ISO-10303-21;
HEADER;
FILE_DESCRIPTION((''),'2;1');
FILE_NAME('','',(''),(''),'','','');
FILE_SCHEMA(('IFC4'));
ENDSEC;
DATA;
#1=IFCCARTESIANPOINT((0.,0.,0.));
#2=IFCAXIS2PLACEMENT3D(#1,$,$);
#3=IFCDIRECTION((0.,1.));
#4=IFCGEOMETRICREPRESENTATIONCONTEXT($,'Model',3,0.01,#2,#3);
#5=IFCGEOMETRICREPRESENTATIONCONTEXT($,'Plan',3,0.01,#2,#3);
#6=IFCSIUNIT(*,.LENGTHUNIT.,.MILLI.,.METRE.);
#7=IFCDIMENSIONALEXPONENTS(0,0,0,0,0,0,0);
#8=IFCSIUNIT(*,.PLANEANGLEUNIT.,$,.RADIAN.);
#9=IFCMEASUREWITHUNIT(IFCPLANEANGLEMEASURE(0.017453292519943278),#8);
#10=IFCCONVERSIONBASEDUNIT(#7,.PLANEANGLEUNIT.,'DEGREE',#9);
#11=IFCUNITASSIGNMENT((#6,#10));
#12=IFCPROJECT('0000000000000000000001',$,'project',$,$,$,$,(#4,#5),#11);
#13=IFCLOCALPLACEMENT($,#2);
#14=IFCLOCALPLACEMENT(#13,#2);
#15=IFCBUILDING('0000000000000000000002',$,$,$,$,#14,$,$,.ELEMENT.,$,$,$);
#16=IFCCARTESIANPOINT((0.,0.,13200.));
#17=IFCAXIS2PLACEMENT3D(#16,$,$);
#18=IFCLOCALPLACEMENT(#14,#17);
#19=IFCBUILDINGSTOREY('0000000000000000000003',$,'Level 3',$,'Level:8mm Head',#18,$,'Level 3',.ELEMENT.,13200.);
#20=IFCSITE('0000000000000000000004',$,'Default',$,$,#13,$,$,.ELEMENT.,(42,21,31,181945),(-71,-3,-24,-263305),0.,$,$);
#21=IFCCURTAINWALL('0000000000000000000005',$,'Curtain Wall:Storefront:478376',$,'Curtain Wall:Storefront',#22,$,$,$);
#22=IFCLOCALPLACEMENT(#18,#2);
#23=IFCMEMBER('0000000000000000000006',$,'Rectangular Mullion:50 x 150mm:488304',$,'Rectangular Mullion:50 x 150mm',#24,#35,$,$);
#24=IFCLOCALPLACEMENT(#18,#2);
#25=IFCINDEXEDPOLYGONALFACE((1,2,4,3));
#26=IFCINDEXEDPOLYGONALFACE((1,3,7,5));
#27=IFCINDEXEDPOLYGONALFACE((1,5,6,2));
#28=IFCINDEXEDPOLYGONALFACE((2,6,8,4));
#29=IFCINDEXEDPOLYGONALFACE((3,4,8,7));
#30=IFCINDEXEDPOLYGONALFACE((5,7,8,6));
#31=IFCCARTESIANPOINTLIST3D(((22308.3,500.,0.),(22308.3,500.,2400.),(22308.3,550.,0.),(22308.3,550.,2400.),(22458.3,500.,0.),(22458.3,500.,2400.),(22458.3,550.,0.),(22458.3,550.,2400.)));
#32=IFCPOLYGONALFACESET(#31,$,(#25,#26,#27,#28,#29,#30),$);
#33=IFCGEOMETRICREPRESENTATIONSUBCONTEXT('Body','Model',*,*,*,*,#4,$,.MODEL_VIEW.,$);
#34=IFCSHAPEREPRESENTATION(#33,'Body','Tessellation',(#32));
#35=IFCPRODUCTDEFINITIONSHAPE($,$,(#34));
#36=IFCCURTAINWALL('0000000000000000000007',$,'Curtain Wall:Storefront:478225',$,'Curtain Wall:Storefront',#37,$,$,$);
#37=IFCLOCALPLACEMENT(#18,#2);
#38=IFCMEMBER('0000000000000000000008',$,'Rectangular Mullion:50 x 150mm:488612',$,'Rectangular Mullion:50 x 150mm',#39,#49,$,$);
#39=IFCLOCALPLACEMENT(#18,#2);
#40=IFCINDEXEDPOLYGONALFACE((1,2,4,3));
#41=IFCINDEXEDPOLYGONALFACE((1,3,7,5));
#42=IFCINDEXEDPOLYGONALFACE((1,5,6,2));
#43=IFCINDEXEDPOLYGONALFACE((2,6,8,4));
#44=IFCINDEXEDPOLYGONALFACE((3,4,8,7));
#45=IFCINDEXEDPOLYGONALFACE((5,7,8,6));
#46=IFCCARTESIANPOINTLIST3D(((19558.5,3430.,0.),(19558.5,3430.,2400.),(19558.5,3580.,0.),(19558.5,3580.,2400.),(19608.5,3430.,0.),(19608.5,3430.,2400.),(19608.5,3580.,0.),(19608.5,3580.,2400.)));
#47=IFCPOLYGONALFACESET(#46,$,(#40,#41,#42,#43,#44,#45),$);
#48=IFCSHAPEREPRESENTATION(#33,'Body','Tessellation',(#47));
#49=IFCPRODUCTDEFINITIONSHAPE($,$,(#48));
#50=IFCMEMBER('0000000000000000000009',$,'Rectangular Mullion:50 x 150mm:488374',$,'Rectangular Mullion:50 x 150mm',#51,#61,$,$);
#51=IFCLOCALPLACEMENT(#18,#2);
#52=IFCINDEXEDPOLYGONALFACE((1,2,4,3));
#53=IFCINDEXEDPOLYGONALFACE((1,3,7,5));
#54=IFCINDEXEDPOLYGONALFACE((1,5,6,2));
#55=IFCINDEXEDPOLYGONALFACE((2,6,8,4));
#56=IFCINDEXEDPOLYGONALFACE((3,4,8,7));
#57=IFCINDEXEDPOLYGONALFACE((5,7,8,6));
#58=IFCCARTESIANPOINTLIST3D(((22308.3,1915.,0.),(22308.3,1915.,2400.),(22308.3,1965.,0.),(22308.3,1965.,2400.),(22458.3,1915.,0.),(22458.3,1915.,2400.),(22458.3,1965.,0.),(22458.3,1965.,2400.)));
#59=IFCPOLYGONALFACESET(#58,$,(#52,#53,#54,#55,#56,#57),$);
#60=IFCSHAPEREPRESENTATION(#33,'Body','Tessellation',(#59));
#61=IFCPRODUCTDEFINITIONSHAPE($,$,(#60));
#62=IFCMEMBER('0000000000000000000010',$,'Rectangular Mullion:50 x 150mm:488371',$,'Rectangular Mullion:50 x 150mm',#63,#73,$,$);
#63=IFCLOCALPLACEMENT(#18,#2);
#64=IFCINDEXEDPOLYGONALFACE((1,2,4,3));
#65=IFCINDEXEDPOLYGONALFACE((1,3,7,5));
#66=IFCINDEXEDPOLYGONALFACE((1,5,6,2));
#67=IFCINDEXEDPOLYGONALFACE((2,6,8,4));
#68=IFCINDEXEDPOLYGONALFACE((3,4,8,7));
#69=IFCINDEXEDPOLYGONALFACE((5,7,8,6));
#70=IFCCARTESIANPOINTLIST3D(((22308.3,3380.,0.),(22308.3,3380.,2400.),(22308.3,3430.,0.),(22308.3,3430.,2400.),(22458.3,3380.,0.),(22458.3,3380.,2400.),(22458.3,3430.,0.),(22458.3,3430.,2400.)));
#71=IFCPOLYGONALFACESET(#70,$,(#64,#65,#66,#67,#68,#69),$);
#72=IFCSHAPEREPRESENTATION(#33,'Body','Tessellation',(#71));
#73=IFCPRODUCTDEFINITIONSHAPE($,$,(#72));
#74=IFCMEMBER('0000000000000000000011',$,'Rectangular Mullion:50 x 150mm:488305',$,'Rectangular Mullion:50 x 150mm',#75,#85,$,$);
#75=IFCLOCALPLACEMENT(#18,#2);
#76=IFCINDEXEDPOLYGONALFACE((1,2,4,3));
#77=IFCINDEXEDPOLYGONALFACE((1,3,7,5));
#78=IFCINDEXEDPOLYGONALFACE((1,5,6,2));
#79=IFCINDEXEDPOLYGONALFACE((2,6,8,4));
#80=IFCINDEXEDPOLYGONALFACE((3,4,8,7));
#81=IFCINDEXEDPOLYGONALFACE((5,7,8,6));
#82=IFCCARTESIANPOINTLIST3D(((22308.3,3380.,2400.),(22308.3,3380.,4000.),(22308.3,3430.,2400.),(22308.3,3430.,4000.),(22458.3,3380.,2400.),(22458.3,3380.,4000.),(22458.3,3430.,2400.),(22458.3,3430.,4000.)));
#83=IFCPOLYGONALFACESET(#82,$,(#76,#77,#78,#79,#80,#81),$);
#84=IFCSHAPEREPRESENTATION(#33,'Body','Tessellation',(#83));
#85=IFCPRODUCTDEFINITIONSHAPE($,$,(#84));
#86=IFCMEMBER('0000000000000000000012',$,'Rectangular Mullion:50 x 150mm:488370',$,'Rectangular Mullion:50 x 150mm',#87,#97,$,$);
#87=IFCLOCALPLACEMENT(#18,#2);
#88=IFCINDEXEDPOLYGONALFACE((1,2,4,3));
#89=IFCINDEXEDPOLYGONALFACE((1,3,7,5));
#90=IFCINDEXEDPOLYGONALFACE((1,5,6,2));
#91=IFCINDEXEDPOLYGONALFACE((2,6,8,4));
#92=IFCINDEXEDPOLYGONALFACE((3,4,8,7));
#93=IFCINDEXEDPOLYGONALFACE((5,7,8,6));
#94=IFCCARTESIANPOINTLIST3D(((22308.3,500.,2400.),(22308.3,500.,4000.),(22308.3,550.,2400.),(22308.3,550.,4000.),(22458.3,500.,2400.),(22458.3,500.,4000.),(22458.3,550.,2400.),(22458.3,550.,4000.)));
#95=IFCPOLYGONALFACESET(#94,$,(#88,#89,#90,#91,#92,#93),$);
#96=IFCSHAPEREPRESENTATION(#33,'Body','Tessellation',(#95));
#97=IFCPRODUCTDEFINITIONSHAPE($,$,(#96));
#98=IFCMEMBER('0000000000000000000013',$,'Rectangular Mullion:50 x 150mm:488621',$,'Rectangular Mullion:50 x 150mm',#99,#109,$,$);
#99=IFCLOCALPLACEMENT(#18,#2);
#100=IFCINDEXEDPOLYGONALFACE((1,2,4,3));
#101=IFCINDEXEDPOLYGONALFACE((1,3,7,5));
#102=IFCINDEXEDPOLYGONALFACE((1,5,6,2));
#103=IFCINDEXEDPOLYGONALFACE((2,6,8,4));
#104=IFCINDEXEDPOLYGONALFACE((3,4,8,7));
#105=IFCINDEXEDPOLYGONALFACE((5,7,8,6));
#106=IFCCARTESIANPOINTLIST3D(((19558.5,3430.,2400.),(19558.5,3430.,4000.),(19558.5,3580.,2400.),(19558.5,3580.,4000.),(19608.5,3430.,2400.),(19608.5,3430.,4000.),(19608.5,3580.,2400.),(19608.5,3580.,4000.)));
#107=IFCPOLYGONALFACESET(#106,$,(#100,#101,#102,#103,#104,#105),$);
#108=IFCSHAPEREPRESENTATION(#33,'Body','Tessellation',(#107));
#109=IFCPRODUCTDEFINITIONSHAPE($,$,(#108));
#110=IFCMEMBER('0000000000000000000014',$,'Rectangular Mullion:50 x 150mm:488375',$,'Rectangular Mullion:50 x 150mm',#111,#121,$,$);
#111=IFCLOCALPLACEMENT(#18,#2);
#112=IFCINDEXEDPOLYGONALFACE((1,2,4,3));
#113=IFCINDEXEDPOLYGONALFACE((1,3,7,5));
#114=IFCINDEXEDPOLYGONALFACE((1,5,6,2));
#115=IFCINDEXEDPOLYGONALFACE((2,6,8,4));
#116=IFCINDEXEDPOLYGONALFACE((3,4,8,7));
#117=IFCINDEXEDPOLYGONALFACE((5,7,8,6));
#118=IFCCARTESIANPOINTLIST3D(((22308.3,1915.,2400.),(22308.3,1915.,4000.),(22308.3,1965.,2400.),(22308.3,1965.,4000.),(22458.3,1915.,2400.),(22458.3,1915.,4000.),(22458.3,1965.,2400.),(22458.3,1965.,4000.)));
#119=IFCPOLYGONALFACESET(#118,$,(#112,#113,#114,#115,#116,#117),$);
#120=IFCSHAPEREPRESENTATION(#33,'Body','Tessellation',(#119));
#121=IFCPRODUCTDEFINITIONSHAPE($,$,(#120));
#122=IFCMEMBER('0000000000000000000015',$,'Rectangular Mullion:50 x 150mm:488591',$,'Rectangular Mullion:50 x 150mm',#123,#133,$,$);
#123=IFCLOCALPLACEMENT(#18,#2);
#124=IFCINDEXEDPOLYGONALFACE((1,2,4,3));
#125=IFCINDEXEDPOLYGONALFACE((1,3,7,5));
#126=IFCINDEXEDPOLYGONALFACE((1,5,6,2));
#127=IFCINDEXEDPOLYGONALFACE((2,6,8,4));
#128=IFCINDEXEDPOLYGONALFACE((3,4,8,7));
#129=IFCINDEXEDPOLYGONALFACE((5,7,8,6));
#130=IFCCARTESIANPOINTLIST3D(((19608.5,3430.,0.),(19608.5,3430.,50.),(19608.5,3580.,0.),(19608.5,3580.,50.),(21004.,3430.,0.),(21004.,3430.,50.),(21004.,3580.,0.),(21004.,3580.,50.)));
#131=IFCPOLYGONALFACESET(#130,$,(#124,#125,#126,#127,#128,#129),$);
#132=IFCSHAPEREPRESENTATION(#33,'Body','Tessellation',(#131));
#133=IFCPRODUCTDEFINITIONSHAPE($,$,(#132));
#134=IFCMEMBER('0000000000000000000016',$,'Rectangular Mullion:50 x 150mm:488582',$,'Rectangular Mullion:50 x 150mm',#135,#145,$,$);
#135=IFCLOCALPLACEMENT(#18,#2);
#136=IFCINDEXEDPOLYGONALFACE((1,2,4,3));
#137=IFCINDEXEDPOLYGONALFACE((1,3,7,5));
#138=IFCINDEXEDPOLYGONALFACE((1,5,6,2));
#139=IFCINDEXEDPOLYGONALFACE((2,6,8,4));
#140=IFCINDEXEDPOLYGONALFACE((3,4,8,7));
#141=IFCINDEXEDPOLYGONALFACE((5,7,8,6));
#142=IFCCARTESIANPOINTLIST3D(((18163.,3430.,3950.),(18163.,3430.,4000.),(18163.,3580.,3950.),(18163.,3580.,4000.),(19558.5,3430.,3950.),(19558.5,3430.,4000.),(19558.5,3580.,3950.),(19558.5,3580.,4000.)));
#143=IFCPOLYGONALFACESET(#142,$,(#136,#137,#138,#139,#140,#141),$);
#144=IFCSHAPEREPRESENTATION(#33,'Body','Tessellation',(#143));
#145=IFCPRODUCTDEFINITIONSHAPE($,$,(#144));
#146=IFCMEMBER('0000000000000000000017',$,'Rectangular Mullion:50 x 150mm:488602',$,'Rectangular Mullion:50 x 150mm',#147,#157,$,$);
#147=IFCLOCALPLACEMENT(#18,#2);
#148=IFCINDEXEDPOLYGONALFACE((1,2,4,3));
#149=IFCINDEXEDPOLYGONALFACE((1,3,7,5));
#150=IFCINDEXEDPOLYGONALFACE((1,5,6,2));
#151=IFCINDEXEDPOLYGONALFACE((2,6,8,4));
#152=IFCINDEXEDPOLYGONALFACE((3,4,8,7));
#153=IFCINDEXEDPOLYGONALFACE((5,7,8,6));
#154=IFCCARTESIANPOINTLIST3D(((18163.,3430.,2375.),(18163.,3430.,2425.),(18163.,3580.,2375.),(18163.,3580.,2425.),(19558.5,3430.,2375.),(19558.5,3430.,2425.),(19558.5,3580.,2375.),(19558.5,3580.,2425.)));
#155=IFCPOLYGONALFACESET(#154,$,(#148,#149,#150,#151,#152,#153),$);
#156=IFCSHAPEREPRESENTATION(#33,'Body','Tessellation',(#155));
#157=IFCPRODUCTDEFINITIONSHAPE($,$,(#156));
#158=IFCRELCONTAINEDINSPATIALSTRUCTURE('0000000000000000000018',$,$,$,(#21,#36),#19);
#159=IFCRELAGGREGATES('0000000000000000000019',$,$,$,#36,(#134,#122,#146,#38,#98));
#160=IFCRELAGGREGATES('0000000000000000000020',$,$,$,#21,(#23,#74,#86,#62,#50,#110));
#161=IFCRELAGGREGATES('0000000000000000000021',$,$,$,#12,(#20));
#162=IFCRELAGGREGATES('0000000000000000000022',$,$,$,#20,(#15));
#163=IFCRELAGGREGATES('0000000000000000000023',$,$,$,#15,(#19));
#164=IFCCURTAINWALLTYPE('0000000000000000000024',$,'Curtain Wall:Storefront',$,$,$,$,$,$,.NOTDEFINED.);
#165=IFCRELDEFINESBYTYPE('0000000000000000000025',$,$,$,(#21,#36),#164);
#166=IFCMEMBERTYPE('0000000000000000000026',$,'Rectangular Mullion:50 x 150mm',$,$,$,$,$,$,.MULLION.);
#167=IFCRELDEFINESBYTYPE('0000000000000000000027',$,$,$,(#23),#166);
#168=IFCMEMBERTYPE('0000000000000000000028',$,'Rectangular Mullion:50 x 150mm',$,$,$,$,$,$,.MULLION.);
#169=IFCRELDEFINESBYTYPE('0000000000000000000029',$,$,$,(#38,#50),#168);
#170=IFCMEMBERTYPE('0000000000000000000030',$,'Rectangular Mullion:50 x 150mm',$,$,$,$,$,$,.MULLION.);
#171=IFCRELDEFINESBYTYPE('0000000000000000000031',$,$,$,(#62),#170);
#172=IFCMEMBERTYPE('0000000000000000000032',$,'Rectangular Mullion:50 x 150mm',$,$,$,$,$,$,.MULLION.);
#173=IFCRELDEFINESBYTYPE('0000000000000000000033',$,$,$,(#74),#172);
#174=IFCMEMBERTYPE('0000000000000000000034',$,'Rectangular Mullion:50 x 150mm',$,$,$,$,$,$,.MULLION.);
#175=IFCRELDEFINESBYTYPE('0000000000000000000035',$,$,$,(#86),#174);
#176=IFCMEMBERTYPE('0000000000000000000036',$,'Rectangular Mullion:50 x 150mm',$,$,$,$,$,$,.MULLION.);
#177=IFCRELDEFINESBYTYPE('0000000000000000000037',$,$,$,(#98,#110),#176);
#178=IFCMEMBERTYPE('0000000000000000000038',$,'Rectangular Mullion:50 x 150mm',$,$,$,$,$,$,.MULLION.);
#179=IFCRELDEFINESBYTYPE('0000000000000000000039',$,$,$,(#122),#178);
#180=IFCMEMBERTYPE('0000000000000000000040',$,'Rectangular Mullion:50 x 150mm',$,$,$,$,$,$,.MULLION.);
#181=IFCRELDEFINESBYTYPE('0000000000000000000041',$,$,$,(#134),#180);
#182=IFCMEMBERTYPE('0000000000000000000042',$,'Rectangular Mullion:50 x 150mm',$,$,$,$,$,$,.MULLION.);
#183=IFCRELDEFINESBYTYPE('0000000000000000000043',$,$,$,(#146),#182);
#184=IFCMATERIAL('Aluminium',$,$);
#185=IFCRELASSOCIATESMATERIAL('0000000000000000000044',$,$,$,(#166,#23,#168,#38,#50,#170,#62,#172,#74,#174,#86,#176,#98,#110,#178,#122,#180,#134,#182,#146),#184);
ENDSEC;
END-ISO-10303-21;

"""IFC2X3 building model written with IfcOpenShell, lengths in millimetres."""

from ifc_helpers import new_model, entity, si_unit, converted_unit, direction, frame, origin, origin_2d_with_axis, place, context, subcontext, project, spatial, rectangle, extrude, source, transform, mapped, material, type_object, type_shapes, element, aggregate, save


model = new_model("IFC2X3")

# Units and contexts
model_context = context("Model", 3, precision=0.01, world=origin(), true_north=direction((0.0, 1.0)))
plan_context = context("Plan", 3, precision=0.01, world=origin(), true_north=direction((0.0, 1.0)))
body_context = subcontext(model_context, "Body", "Model", "MODEL_VIEW")
ifc_project = project(units=[si_unit("LENGTHUNIT", "METRE", prefix="MILLI"), converted_unit("PLANEANGLEUNIT", "DEGREE", entity("IfcPlaneAngleMeasure", 0.017453292519943278), si_unit("PLANEANGLEUNIT", "RADIAN"), dimensions=[0, 0, 0, 0, 0, 0, 0])], contexts=[model_context, plan_context])

# Site, building, storey
site_placement = place(None, origin())
site = spatial("IfcSite", under=ifc_project, at=site_placement, Name="Default", CompositionType="ELEMENT", RefLatitude=(42, 21, 31, 181945), RefLongitude=(-71, -3, -24, -263305), RefElevation=0.0)
building_placement = place(site_placement, origin())
building = spatial("IfcBuilding", under=site, at=building_placement, CompositionType="ELEMENT")
storey_placement = place(building_placement, frame((0.0, 0.0, 13200.0)))
storey = spatial("IfcBuildingStorey", under=building, at=storey_placement, Name="Level 3", ObjectType="Level:8mm Head", LongName="Level 3", CompositionType="ELEMENT", Elevation=13200.0)

# Curtain walls, members
curtain_wall_type = type_object("IfcCurtainWallType", Name="Curtain Wall:Storefront", PredefinedType="NOTDEFINED")
curtain_wall_1_placement = place(storey_placement, frame((0.0, 0.0, -13200.0)))
curtain_wall_1 = element("IfcCurtainWall", 1, at=curtain_wall_1_placement, inside=storey, type_object=curtain_wall_type, Name="Curtain Wall:Storefront:478376", ObjectType="Curtain Wall:Storefront")
ifc_material_1 = material(Name="Aluminium")
member_type_1 = type_object("IfcMemberType", Name="Rectangular Mullion:50 x 150mm", PredefinedType="MULLION", material=ifc_material_1)
shared_shape_1 = source(origin(), body_context, "Body", "SweptSolid", [
    extrude(rectangle(XDim=50.0, YDim=150.0, at=origin_2d_with_axis()), frame((-25.0, 0.0, -2400.0), z_axis=(0.0, 0.0, 1.0), x_axis=(-1.0, 0.0, 0.0)), (0.0, 0.0, 1.0), 2400.0),
])
type_shapes(member_type_1, [shared_shape_1])
member_1_placement = place(curtain_wall_1_placement, frame((22383.3, 500.0, 13200.0), z_axis=(0.0, 0.0, -1.0), x_axis=(0.0, -1.0, 0.0)))
member_1 = element("IfcMember", 2, at=member_1_placement, type_object=member_type_1, material=ifc_material_1, Name="Rectangular Mullion:50 x 150mm:488304", ObjectType="Rectangular Mullion:50 x 150mm", context=body_context, shape_type="MappedRepresentation", body=[
    mapped(shared_shape_1, transform((0.0, 0.0, 0.0), scale=1.0)),
])
curtain_wall_2_placement = place(storey_placement, frame((0.0, 0.0, -13200.0)))
curtain_wall_2 = element("IfcCurtainWall", 3, at=curtain_wall_2_placement, inside=storey, type_object=curtain_wall_type, Name="Curtain Wall:Storefront:478225", ObjectType="Curtain Wall:Storefront")
member_type_2 = type_object("IfcMemberType", Name="Rectangular Mullion:50 x 150mm", PredefinedType="MULLION", material=ifc_material_1)
shared_shape_2 = source(origin(), body_context, "Body", "SweptSolid", [
    extrude(rectangle(XDim=50.0, YDim=150.0, at=origin_2d_with_axis()), frame((0.0, 0.0, -2400.0), z_axis=(0.0, 0.0, 1.0), x_axis=(-1.0, 0.0, 0.0)), (0.0, 0.0, 1.0), 2400.0),
])
type_shapes(member_type_2, [shared_shape_2])
member_2_placement = place(curtain_wall_2_placement, frame((19583.5, 3505.0, 13200.0), z_axis=(0.0, 0.0, -1.0), x_axis=(1.0, 0.0, 0.0)))
member_2 = element("IfcMember", 4, at=member_2_placement, type_object=member_type_2, material=ifc_material_1, Name="Rectangular Mullion:50 x 150mm:488612", ObjectType="Rectangular Mullion:50 x 150mm", context=body_context, shape_type="MappedRepresentation", body=[
    mapped(shared_shape_2, transform((0.0, 0.0, 0.0), scale=1.0)),
])

# Members
member_3_placement = place(curtain_wall_1_placement, frame((22383.3, 1940.0, 13200.0), z_axis=(0.0, 0.0, -1.0), x_axis=(0.0, -1.0, 0.0)))
member_3 = element("IfcMember", 5, at=member_3_placement, type_object=member_type_2, material=ifc_material_1, Name="Rectangular Mullion:50 x 150mm:488374", ObjectType="Rectangular Mullion:50 x 150mm", context=body_context, shape_type="MappedRepresentation", body=[
    mapped(shared_shape_2, transform((0.0, 0.0, 0.0), scale=1.0)),
])
member_type_3 = type_object("IfcMemberType", Name="Rectangular Mullion:50 x 150mm", PredefinedType="MULLION", material=ifc_material_1)
shared_shape_3 = source(origin(), body_context, "Body", "SweptSolid", [
    extrude(rectangle(XDim=50.0, YDim=150.0, at=origin_2d_with_axis()), frame((-25.0, 0.0, -2400.0), z_axis=(0.0, 0.0, 1.0), x_axis=(-1.0, 0.0, 0.0)), (0.0, 0.0, 1.0), 2400.0),
])
type_shapes(member_type_3, [shared_shape_3])
member_4_placement = place(curtain_wall_1_placement, frame((22383.3, 3430.0, 15600.0), z_axis=(0.0, 0.0, 1.0), x_axis=(0.0, 1.0, 0.0)))
member_4 = element("IfcMember", 6, at=member_4_placement, type_object=member_type_3, material=ifc_material_1, Name="Rectangular Mullion:50 x 150mm:488371", ObjectType="Rectangular Mullion:50 x 150mm", context=body_context, shape_type="MappedRepresentation", body=[
    mapped(shared_shape_3, transform((0.0, 0.0, 0.0), scale=1.0)),
])
member_type_4 = type_object("IfcMemberType", Name="Rectangular Mullion:50 x 150mm", PredefinedType="MULLION", material=ifc_material_1)
shared_shape_4 = source(origin(), body_context, "Body", "SweptSolid", [
    extrude(rectangle(XDim=50.0, YDim=150.0, at=origin_2d_with_axis()), frame((-25.0, 0.0, -1600.0), z_axis=(0.0, 0.0, 1.0), x_axis=(-1.0, 0.0, 0.0)), (0.0, 0.0, 1.0), 1600.0),
])
type_shapes(member_type_4, [shared_shape_4])
member_5_placement = place(curtain_wall_1_placement, frame((22383.3, 3430.0, 17200.0), z_axis=(0.0, 0.0, 1.0), x_axis=(0.0, 1.0, 0.0)))
member_5 = element("IfcMember", 7, at=member_5_placement, type_object=member_type_4, material=ifc_material_1, Name="Rectangular Mullion:50 x 150mm:488305", ObjectType="Rectangular Mullion:50 x 150mm", context=body_context, shape_type="MappedRepresentation", body=[
    mapped(shared_shape_4, transform((0.0, 0.0, 0.0), scale=1.0)),
])
member_type_5 = type_object("IfcMemberType", Name="Rectangular Mullion:50 x 150mm", PredefinedType="MULLION", material=ifc_material_1)
shared_shape_5 = source(origin(), body_context, "Body", "SweptSolid", [
    extrude(rectangle(XDim=50.0, YDim=150.0, at=origin_2d_with_axis()), frame((-25.0, 0.0, -1600.0), z_axis=(0.0, 0.0, 1.0), x_axis=(-1.0, 0.0, 0.0)), (0.0, 0.0, 1.0), 1600.0),
])
type_shapes(member_type_5, [shared_shape_5])
member_6_placement = place(curtain_wall_1_placement, frame((22383.3, 500.0, 15600.0), z_axis=(0.0, 0.0, -1.0), x_axis=(0.0, -1.0, 0.0)))
member_6 = element("IfcMember", 8, at=member_6_placement, type_object=member_type_5, material=ifc_material_1, Name="Rectangular Mullion:50 x 150mm:488370", ObjectType="Rectangular Mullion:50 x 150mm", context=body_context, shape_type="MappedRepresentation", body=[
    mapped(shared_shape_5, transform((0.0, 0.0, 0.0), scale=1.0)),
])
member_type_6 = type_object("IfcMemberType", Name="Rectangular Mullion:50 x 150mm", PredefinedType="MULLION", material=ifc_material_1)
shared_shape_6 = source(origin(), body_context, "Body", "SweptSolid", [
    extrude(rectangle(XDim=50.0, YDim=150.0, at=origin_2d_with_axis()), frame((0.0, 0.0, -1600.0), z_axis=(0.0, 0.0, 1.0), x_axis=(-1.0, 0.0, 0.0)), (0.0, 0.0, 1.0), 1600.0),
])
type_shapes(member_type_6, [shared_shape_6])
member_7_placement = place(curtain_wall_2_placement, frame((19583.5, 3505.0, 15600.0), z_axis=(0.0, 0.0, -1.0), x_axis=(1.0, 0.0, 0.0)))
member_7 = element("IfcMember", 9, at=member_7_placement, type_object=member_type_6, material=ifc_material_1, Name="Rectangular Mullion:50 x 150mm:488621", ObjectType="Rectangular Mullion:50 x 150mm", context=body_context, shape_type="MappedRepresentation", body=[
    mapped(shared_shape_6, transform((0.0, 0.0, 0.0), scale=1.0)),
])
member_8_placement = place(curtain_wall_1_placement, frame((22383.3, 1940.0, 15600.0), z_axis=(0.0, 0.0, -1.0), x_axis=(0.0, -1.0, 0.0)))
member_8 = element("IfcMember", 10, at=member_8_placement, type_object=member_type_6, material=ifc_material_1, Name="Rectangular Mullion:50 x 150mm:488375", ObjectType="Rectangular Mullion:50 x 150mm", context=body_context, shape_type="MappedRepresentation", body=[
    mapped(shared_shape_6, transform((0.0, 0.0, 0.0), scale=1.0)),
])
member_type_7 = type_object("IfcMemberType", Name="Rectangular Mullion:50 x 150mm", PredefinedType="MULLION", material=ifc_material_1)
shared_shape_7 = source(origin(), body_context, "Body", "SweptSolid", [
    extrude(rectangle(XDim=50.0, YDim=150.0, at=origin_2d_with_axis()), frame((-25.0, 0.0, -1395.5), z_axis=(0.0, 0.0, 1.0), x_axis=(-1.0, 0.0, 0.0)), (0.0, 0.0, 1.0), 1395.5),
])
type_shapes(member_type_7, [shared_shape_7])
member_9_placement = place(curtain_wall_2_placement, frame((19608.5, 3505.0, 13200.0), z_axis=(-1.0, 0.0, 0.0), x_axis=(0.0, 0.0, -1.0)))
member_9 = element("IfcMember", 11, at=member_9_placement, type_object=member_type_7, material=ifc_material_1, Name="Rectangular Mullion:50 x 150mm:488591", ObjectType="Rectangular Mullion:50 x 150mm", context=body_context, shape_type="MappedRepresentation", body=[
    mapped(shared_shape_7, transform((0.0, 0.0, 0.0), scale=1.0)),
])
member_type_8 = type_object("IfcMemberType", Name="Rectangular Mullion:50 x 150mm", PredefinedType="MULLION", material=ifc_material_1)
shared_shape_8 = source(origin(), body_context, "Body", "SweptSolid", [
    extrude(rectangle(XDim=50.0, YDim=150.0, at=origin_2d_with_axis()), frame((-25.0, 0.0, -1395.5), z_axis=(0.0, 0.0, 1.0), x_axis=(-1.0, 0.0, 0.0)), (0.0, 0.0, 1.0), 1395.5),
])
type_shapes(member_type_8, [shared_shape_8])
member_10_placement = place(curtain_wall_2_placement, frame((19558.5, 3505.0, 17200.0), z_axis=(1.0, 0.0, 0.0), x_axis=(0.0, 0.0, 1.0)))
member_10 = element("IfcMember", 12, at=member_10_placement, type_object=member_type_8, material=ifc_material_1, Name="Rectangular Mullion:50 x 150mm:488582", ObjectType="Rectangular Mullion:50 x 150mm", context=body_context, shape_type="MappedRepresentation", body=[
    mapped(shared_shape_8, transform((0.0, 0.0, 0.0), scale=1.0)),
])
member_type_9 = type_object("IfcMemberType", Name="Rectangular Mullion:50 x 150mm", PredefinedType="MULLION", material=ifc_material_1)
shared_shape_9 = source(origin(), body_context, "Body", "SweptSolid", [
    extrude(rectangle(XDim=50.0, YDim=150.0, at=origin_2d_with_axis()), frame((0.0, 0.0, -1395.5), z_axis=(0.0, 0.0, 1.0), x_axis=(-1.0, 0.0, 0.0)), (0.0, 0.0, 1.0), 1395.5),
])
type_shapes(member_type_9, [shared_shape_9])
member_11_placement = place(curtain_wall_2_placement, frame((19558.5, 3505.0, 15600.0), z_axis=(1.0, 0.0, 0.0), x_axis=(0.0, 0.0, 1.0)))
member_11 = element("IfcMember", 13, at=member_11_placement, type_object=member_type_9, material=ifc_material_1, Name="Rectangular Mullion:50 x 150mm:488602", ObjectType="Rectangular Mullion:50 x 150mm", context=body_context, shape_type="MappedRepresentation", body=[
    mapped(shared_shape_9, transform((0.0, 0.0, 0.0), scale=1.0)),
])

aggregate(curtain_wall_2, [member_10, member_9, member_11, member_2, member_7])

aggregate(curtain_wall_1, [member_1, member_5, member_6, member_4, member_3, member_8])

save(model, "model.ifc")
